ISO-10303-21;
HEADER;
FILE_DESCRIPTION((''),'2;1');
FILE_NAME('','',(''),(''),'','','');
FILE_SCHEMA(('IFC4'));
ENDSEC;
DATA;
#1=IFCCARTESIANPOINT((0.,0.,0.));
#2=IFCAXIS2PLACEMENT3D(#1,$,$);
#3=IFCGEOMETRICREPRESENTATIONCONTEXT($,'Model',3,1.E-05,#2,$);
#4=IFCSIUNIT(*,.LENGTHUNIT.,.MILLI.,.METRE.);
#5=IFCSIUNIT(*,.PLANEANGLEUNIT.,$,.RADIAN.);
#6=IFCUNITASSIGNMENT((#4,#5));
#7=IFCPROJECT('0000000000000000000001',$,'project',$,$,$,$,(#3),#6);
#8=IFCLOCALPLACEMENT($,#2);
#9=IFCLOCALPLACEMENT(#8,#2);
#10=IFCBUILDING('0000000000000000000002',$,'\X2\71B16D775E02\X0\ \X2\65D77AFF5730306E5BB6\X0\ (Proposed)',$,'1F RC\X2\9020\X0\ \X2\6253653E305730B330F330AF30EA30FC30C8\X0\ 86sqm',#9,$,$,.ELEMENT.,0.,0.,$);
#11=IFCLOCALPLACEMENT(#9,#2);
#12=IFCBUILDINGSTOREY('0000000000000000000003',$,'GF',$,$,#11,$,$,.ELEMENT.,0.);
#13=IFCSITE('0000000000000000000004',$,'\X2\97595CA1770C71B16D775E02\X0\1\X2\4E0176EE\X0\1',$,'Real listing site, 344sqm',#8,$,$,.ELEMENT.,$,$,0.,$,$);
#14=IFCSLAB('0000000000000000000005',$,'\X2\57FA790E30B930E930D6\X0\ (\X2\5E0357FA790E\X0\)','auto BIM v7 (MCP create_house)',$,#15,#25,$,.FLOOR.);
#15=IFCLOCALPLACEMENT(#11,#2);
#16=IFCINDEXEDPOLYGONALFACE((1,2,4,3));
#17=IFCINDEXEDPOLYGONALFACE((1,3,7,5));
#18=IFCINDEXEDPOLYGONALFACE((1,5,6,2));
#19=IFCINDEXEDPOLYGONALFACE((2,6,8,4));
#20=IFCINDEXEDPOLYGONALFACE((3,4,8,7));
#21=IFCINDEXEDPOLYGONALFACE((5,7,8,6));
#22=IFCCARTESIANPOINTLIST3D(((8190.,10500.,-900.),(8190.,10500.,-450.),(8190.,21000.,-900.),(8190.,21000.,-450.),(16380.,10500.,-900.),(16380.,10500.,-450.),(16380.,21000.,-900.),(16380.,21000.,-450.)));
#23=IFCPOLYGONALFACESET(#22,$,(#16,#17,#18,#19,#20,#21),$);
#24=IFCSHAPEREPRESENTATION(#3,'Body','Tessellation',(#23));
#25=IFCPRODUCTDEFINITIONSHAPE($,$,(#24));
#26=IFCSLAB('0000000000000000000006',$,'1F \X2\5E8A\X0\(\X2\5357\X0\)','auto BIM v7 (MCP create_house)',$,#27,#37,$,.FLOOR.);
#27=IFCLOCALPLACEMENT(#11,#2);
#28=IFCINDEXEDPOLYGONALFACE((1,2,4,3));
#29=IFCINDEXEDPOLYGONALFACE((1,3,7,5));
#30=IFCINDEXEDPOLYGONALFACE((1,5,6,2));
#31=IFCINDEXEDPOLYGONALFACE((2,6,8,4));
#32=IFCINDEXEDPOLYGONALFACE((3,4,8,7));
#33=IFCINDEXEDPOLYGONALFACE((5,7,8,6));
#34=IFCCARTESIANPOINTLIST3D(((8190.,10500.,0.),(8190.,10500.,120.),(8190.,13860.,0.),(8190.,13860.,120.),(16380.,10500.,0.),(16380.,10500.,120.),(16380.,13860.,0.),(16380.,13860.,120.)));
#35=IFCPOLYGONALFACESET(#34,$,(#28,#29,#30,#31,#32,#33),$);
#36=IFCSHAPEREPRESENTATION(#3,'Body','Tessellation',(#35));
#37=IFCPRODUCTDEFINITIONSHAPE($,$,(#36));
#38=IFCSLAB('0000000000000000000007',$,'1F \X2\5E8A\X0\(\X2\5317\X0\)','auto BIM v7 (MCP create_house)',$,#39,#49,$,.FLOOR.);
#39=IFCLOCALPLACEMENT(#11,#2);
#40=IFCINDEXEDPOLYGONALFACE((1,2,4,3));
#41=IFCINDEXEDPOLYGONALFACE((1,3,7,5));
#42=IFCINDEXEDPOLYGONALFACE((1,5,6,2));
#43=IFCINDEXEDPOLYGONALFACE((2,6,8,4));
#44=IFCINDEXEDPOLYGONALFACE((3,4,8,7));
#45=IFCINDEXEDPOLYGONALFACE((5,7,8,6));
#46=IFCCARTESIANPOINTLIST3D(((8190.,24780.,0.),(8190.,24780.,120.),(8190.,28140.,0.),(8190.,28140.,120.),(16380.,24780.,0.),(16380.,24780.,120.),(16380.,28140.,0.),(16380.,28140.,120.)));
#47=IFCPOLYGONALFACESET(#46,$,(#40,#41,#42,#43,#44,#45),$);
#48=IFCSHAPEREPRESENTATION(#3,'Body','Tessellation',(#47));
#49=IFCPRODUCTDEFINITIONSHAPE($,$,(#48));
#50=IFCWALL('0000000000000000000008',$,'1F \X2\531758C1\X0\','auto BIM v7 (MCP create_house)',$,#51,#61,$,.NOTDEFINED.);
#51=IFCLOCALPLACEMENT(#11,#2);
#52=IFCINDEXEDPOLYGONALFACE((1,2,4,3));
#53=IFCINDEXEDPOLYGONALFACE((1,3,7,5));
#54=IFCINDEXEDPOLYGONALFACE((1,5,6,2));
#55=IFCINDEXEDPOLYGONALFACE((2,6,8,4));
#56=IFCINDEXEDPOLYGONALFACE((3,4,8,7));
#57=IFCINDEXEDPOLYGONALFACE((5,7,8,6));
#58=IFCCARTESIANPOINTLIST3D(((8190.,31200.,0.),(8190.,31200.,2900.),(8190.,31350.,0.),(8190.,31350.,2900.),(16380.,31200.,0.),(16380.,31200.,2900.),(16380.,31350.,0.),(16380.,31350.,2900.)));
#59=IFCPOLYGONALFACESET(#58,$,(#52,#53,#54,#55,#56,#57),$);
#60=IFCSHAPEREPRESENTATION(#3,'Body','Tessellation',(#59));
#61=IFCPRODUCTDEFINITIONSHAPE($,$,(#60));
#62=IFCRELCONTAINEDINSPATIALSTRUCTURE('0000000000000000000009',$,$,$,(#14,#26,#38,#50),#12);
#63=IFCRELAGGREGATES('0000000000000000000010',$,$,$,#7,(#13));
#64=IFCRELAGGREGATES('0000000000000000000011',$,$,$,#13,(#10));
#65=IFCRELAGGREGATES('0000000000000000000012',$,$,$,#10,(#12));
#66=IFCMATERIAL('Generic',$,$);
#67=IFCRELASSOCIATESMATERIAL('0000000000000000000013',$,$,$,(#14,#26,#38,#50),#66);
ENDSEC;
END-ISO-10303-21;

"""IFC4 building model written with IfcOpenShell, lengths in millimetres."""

from ifc_helpers import new_model, si_unit, frame, frame_2d, origin, place, context, project, spatial, rectangle, extrude, material, element, save


model = new_model("IFC4")

# Units and contexts
model_context = context("Model", 3, precision=1e-05, world=origin())
ifc_project = project(units=[si_unit("LENGTHUNIT", "METRE", prefix="MILLI"), si_unit("PLANEANGLEUNIT", "RADIAN")], contexts=[model_context])

# Site, building, storey
site_placement = place(None, origin())
site = spatial("IfcSite", under=ifc_project, at=site_placement, Name="静岡県熱海市1丁目1", ObjectType="Real listing site, 344sqm", CompositionType="ELEMENT", RefElevation=0.0)
building_placement = place(site_placement, origin())
building = spatial("IfcBuilding", under=site, at=building_placement, Name="熱海市 旗竿地の家 (Proposed)", ObjectType="1F RC造 打放しコンクリート 86sqm", CompositionType="ELEMENT", ElevationOfRefHeight=0.0, ElevationOfTerrain=0.0)
storey_placement = place(building_placement, origin())
storey = spatial("IfcBuildingStorey", under=building, at=storey_placement, Name="GF", CompositionType="ELEMENT", Elevation=0.0)

# Slabs
ifc_material = material(Name="Generic")
slab_1_placement = place(storey_placement, frame((4095.0, 5250.0, -450.0)))
element("IfcSlab", 1, at=slab_1_placement, inside=storey, material=ifc_material, Name="基礎スラブ (布基礎)", Description="auto BIM v7 (MCP create_house)", PredefinedType="FLOOR", context=model_context, shape_type="SweptSolid", body=[
    extrude(rectangle(XDim=8190.0, YDim=10500.0, at=frame_2d((4095.0, 5250.0))), frame((4095.0, 5250.0, -450.0)), (0.0, 0.0, 1.0), 450.0),
])
slab_2_placement = place(storey_placement, frame((4095.0, 5250.0, 0.0)))
element("IfcSlab", 2, at=slab_2_placement, inside=storey, material=ifc_material, Name="1F 床(南)", Description="auto BIM v7 (MCP create_house)", PredefinedType="FLOOR", context=model_context, shape_type="SweptSolid", body=[
    extrude(rectangle(XDim=8190.0, YDim=3360.0, at=frame_2d((4095.0, 1680.0))), frame((4095.0, 5250.0, 0.0)), (0.0, 0.0, 1.0), 120.0),
])
slab_3_placement = place(storey_placement, frame((4095.0, 12390.0, 0.0)))
element("IfcSlab", 3, at=slab_3_placement, inside=storey, material=ifc_material, Name="1F 床(北)", Description="auto BIM v7 (MCP create_house)", PredefinedType="FLOOR", context=model_context, shape_type="SweptSolid", body=[
    extrude(rectangle(XDim=8190.0, YDim=3360.0, at=frame_2d((4095.0, 1680.0))), frame((4095.0, 12390.0, 0.0)), (0.0, 0.0, 1.0), 120.0),
])

# Wall
wall_1_placement = place(storey_placement, frame((4095.0, 15600.0, 0.0)))
element("IfcWall", 4, at=wall_1_placement, inside=storey, material=ifc_material, Name="1F 北壁", Description="auto BIM v7 (MCP create_house)", PredefinedType="NOTDEFINED", context=model_context, shape_type="SweptSolid", body=[
    extrude(rectangle(XDim=8190.0, YDim=150.0, at=frame_2d((4095.0, 75.0))), frame((4095.0, 15600.0, 0.0)), (0.0, 0.0, 1.0), 2900.0),
])

save(model, "model.ifc")
